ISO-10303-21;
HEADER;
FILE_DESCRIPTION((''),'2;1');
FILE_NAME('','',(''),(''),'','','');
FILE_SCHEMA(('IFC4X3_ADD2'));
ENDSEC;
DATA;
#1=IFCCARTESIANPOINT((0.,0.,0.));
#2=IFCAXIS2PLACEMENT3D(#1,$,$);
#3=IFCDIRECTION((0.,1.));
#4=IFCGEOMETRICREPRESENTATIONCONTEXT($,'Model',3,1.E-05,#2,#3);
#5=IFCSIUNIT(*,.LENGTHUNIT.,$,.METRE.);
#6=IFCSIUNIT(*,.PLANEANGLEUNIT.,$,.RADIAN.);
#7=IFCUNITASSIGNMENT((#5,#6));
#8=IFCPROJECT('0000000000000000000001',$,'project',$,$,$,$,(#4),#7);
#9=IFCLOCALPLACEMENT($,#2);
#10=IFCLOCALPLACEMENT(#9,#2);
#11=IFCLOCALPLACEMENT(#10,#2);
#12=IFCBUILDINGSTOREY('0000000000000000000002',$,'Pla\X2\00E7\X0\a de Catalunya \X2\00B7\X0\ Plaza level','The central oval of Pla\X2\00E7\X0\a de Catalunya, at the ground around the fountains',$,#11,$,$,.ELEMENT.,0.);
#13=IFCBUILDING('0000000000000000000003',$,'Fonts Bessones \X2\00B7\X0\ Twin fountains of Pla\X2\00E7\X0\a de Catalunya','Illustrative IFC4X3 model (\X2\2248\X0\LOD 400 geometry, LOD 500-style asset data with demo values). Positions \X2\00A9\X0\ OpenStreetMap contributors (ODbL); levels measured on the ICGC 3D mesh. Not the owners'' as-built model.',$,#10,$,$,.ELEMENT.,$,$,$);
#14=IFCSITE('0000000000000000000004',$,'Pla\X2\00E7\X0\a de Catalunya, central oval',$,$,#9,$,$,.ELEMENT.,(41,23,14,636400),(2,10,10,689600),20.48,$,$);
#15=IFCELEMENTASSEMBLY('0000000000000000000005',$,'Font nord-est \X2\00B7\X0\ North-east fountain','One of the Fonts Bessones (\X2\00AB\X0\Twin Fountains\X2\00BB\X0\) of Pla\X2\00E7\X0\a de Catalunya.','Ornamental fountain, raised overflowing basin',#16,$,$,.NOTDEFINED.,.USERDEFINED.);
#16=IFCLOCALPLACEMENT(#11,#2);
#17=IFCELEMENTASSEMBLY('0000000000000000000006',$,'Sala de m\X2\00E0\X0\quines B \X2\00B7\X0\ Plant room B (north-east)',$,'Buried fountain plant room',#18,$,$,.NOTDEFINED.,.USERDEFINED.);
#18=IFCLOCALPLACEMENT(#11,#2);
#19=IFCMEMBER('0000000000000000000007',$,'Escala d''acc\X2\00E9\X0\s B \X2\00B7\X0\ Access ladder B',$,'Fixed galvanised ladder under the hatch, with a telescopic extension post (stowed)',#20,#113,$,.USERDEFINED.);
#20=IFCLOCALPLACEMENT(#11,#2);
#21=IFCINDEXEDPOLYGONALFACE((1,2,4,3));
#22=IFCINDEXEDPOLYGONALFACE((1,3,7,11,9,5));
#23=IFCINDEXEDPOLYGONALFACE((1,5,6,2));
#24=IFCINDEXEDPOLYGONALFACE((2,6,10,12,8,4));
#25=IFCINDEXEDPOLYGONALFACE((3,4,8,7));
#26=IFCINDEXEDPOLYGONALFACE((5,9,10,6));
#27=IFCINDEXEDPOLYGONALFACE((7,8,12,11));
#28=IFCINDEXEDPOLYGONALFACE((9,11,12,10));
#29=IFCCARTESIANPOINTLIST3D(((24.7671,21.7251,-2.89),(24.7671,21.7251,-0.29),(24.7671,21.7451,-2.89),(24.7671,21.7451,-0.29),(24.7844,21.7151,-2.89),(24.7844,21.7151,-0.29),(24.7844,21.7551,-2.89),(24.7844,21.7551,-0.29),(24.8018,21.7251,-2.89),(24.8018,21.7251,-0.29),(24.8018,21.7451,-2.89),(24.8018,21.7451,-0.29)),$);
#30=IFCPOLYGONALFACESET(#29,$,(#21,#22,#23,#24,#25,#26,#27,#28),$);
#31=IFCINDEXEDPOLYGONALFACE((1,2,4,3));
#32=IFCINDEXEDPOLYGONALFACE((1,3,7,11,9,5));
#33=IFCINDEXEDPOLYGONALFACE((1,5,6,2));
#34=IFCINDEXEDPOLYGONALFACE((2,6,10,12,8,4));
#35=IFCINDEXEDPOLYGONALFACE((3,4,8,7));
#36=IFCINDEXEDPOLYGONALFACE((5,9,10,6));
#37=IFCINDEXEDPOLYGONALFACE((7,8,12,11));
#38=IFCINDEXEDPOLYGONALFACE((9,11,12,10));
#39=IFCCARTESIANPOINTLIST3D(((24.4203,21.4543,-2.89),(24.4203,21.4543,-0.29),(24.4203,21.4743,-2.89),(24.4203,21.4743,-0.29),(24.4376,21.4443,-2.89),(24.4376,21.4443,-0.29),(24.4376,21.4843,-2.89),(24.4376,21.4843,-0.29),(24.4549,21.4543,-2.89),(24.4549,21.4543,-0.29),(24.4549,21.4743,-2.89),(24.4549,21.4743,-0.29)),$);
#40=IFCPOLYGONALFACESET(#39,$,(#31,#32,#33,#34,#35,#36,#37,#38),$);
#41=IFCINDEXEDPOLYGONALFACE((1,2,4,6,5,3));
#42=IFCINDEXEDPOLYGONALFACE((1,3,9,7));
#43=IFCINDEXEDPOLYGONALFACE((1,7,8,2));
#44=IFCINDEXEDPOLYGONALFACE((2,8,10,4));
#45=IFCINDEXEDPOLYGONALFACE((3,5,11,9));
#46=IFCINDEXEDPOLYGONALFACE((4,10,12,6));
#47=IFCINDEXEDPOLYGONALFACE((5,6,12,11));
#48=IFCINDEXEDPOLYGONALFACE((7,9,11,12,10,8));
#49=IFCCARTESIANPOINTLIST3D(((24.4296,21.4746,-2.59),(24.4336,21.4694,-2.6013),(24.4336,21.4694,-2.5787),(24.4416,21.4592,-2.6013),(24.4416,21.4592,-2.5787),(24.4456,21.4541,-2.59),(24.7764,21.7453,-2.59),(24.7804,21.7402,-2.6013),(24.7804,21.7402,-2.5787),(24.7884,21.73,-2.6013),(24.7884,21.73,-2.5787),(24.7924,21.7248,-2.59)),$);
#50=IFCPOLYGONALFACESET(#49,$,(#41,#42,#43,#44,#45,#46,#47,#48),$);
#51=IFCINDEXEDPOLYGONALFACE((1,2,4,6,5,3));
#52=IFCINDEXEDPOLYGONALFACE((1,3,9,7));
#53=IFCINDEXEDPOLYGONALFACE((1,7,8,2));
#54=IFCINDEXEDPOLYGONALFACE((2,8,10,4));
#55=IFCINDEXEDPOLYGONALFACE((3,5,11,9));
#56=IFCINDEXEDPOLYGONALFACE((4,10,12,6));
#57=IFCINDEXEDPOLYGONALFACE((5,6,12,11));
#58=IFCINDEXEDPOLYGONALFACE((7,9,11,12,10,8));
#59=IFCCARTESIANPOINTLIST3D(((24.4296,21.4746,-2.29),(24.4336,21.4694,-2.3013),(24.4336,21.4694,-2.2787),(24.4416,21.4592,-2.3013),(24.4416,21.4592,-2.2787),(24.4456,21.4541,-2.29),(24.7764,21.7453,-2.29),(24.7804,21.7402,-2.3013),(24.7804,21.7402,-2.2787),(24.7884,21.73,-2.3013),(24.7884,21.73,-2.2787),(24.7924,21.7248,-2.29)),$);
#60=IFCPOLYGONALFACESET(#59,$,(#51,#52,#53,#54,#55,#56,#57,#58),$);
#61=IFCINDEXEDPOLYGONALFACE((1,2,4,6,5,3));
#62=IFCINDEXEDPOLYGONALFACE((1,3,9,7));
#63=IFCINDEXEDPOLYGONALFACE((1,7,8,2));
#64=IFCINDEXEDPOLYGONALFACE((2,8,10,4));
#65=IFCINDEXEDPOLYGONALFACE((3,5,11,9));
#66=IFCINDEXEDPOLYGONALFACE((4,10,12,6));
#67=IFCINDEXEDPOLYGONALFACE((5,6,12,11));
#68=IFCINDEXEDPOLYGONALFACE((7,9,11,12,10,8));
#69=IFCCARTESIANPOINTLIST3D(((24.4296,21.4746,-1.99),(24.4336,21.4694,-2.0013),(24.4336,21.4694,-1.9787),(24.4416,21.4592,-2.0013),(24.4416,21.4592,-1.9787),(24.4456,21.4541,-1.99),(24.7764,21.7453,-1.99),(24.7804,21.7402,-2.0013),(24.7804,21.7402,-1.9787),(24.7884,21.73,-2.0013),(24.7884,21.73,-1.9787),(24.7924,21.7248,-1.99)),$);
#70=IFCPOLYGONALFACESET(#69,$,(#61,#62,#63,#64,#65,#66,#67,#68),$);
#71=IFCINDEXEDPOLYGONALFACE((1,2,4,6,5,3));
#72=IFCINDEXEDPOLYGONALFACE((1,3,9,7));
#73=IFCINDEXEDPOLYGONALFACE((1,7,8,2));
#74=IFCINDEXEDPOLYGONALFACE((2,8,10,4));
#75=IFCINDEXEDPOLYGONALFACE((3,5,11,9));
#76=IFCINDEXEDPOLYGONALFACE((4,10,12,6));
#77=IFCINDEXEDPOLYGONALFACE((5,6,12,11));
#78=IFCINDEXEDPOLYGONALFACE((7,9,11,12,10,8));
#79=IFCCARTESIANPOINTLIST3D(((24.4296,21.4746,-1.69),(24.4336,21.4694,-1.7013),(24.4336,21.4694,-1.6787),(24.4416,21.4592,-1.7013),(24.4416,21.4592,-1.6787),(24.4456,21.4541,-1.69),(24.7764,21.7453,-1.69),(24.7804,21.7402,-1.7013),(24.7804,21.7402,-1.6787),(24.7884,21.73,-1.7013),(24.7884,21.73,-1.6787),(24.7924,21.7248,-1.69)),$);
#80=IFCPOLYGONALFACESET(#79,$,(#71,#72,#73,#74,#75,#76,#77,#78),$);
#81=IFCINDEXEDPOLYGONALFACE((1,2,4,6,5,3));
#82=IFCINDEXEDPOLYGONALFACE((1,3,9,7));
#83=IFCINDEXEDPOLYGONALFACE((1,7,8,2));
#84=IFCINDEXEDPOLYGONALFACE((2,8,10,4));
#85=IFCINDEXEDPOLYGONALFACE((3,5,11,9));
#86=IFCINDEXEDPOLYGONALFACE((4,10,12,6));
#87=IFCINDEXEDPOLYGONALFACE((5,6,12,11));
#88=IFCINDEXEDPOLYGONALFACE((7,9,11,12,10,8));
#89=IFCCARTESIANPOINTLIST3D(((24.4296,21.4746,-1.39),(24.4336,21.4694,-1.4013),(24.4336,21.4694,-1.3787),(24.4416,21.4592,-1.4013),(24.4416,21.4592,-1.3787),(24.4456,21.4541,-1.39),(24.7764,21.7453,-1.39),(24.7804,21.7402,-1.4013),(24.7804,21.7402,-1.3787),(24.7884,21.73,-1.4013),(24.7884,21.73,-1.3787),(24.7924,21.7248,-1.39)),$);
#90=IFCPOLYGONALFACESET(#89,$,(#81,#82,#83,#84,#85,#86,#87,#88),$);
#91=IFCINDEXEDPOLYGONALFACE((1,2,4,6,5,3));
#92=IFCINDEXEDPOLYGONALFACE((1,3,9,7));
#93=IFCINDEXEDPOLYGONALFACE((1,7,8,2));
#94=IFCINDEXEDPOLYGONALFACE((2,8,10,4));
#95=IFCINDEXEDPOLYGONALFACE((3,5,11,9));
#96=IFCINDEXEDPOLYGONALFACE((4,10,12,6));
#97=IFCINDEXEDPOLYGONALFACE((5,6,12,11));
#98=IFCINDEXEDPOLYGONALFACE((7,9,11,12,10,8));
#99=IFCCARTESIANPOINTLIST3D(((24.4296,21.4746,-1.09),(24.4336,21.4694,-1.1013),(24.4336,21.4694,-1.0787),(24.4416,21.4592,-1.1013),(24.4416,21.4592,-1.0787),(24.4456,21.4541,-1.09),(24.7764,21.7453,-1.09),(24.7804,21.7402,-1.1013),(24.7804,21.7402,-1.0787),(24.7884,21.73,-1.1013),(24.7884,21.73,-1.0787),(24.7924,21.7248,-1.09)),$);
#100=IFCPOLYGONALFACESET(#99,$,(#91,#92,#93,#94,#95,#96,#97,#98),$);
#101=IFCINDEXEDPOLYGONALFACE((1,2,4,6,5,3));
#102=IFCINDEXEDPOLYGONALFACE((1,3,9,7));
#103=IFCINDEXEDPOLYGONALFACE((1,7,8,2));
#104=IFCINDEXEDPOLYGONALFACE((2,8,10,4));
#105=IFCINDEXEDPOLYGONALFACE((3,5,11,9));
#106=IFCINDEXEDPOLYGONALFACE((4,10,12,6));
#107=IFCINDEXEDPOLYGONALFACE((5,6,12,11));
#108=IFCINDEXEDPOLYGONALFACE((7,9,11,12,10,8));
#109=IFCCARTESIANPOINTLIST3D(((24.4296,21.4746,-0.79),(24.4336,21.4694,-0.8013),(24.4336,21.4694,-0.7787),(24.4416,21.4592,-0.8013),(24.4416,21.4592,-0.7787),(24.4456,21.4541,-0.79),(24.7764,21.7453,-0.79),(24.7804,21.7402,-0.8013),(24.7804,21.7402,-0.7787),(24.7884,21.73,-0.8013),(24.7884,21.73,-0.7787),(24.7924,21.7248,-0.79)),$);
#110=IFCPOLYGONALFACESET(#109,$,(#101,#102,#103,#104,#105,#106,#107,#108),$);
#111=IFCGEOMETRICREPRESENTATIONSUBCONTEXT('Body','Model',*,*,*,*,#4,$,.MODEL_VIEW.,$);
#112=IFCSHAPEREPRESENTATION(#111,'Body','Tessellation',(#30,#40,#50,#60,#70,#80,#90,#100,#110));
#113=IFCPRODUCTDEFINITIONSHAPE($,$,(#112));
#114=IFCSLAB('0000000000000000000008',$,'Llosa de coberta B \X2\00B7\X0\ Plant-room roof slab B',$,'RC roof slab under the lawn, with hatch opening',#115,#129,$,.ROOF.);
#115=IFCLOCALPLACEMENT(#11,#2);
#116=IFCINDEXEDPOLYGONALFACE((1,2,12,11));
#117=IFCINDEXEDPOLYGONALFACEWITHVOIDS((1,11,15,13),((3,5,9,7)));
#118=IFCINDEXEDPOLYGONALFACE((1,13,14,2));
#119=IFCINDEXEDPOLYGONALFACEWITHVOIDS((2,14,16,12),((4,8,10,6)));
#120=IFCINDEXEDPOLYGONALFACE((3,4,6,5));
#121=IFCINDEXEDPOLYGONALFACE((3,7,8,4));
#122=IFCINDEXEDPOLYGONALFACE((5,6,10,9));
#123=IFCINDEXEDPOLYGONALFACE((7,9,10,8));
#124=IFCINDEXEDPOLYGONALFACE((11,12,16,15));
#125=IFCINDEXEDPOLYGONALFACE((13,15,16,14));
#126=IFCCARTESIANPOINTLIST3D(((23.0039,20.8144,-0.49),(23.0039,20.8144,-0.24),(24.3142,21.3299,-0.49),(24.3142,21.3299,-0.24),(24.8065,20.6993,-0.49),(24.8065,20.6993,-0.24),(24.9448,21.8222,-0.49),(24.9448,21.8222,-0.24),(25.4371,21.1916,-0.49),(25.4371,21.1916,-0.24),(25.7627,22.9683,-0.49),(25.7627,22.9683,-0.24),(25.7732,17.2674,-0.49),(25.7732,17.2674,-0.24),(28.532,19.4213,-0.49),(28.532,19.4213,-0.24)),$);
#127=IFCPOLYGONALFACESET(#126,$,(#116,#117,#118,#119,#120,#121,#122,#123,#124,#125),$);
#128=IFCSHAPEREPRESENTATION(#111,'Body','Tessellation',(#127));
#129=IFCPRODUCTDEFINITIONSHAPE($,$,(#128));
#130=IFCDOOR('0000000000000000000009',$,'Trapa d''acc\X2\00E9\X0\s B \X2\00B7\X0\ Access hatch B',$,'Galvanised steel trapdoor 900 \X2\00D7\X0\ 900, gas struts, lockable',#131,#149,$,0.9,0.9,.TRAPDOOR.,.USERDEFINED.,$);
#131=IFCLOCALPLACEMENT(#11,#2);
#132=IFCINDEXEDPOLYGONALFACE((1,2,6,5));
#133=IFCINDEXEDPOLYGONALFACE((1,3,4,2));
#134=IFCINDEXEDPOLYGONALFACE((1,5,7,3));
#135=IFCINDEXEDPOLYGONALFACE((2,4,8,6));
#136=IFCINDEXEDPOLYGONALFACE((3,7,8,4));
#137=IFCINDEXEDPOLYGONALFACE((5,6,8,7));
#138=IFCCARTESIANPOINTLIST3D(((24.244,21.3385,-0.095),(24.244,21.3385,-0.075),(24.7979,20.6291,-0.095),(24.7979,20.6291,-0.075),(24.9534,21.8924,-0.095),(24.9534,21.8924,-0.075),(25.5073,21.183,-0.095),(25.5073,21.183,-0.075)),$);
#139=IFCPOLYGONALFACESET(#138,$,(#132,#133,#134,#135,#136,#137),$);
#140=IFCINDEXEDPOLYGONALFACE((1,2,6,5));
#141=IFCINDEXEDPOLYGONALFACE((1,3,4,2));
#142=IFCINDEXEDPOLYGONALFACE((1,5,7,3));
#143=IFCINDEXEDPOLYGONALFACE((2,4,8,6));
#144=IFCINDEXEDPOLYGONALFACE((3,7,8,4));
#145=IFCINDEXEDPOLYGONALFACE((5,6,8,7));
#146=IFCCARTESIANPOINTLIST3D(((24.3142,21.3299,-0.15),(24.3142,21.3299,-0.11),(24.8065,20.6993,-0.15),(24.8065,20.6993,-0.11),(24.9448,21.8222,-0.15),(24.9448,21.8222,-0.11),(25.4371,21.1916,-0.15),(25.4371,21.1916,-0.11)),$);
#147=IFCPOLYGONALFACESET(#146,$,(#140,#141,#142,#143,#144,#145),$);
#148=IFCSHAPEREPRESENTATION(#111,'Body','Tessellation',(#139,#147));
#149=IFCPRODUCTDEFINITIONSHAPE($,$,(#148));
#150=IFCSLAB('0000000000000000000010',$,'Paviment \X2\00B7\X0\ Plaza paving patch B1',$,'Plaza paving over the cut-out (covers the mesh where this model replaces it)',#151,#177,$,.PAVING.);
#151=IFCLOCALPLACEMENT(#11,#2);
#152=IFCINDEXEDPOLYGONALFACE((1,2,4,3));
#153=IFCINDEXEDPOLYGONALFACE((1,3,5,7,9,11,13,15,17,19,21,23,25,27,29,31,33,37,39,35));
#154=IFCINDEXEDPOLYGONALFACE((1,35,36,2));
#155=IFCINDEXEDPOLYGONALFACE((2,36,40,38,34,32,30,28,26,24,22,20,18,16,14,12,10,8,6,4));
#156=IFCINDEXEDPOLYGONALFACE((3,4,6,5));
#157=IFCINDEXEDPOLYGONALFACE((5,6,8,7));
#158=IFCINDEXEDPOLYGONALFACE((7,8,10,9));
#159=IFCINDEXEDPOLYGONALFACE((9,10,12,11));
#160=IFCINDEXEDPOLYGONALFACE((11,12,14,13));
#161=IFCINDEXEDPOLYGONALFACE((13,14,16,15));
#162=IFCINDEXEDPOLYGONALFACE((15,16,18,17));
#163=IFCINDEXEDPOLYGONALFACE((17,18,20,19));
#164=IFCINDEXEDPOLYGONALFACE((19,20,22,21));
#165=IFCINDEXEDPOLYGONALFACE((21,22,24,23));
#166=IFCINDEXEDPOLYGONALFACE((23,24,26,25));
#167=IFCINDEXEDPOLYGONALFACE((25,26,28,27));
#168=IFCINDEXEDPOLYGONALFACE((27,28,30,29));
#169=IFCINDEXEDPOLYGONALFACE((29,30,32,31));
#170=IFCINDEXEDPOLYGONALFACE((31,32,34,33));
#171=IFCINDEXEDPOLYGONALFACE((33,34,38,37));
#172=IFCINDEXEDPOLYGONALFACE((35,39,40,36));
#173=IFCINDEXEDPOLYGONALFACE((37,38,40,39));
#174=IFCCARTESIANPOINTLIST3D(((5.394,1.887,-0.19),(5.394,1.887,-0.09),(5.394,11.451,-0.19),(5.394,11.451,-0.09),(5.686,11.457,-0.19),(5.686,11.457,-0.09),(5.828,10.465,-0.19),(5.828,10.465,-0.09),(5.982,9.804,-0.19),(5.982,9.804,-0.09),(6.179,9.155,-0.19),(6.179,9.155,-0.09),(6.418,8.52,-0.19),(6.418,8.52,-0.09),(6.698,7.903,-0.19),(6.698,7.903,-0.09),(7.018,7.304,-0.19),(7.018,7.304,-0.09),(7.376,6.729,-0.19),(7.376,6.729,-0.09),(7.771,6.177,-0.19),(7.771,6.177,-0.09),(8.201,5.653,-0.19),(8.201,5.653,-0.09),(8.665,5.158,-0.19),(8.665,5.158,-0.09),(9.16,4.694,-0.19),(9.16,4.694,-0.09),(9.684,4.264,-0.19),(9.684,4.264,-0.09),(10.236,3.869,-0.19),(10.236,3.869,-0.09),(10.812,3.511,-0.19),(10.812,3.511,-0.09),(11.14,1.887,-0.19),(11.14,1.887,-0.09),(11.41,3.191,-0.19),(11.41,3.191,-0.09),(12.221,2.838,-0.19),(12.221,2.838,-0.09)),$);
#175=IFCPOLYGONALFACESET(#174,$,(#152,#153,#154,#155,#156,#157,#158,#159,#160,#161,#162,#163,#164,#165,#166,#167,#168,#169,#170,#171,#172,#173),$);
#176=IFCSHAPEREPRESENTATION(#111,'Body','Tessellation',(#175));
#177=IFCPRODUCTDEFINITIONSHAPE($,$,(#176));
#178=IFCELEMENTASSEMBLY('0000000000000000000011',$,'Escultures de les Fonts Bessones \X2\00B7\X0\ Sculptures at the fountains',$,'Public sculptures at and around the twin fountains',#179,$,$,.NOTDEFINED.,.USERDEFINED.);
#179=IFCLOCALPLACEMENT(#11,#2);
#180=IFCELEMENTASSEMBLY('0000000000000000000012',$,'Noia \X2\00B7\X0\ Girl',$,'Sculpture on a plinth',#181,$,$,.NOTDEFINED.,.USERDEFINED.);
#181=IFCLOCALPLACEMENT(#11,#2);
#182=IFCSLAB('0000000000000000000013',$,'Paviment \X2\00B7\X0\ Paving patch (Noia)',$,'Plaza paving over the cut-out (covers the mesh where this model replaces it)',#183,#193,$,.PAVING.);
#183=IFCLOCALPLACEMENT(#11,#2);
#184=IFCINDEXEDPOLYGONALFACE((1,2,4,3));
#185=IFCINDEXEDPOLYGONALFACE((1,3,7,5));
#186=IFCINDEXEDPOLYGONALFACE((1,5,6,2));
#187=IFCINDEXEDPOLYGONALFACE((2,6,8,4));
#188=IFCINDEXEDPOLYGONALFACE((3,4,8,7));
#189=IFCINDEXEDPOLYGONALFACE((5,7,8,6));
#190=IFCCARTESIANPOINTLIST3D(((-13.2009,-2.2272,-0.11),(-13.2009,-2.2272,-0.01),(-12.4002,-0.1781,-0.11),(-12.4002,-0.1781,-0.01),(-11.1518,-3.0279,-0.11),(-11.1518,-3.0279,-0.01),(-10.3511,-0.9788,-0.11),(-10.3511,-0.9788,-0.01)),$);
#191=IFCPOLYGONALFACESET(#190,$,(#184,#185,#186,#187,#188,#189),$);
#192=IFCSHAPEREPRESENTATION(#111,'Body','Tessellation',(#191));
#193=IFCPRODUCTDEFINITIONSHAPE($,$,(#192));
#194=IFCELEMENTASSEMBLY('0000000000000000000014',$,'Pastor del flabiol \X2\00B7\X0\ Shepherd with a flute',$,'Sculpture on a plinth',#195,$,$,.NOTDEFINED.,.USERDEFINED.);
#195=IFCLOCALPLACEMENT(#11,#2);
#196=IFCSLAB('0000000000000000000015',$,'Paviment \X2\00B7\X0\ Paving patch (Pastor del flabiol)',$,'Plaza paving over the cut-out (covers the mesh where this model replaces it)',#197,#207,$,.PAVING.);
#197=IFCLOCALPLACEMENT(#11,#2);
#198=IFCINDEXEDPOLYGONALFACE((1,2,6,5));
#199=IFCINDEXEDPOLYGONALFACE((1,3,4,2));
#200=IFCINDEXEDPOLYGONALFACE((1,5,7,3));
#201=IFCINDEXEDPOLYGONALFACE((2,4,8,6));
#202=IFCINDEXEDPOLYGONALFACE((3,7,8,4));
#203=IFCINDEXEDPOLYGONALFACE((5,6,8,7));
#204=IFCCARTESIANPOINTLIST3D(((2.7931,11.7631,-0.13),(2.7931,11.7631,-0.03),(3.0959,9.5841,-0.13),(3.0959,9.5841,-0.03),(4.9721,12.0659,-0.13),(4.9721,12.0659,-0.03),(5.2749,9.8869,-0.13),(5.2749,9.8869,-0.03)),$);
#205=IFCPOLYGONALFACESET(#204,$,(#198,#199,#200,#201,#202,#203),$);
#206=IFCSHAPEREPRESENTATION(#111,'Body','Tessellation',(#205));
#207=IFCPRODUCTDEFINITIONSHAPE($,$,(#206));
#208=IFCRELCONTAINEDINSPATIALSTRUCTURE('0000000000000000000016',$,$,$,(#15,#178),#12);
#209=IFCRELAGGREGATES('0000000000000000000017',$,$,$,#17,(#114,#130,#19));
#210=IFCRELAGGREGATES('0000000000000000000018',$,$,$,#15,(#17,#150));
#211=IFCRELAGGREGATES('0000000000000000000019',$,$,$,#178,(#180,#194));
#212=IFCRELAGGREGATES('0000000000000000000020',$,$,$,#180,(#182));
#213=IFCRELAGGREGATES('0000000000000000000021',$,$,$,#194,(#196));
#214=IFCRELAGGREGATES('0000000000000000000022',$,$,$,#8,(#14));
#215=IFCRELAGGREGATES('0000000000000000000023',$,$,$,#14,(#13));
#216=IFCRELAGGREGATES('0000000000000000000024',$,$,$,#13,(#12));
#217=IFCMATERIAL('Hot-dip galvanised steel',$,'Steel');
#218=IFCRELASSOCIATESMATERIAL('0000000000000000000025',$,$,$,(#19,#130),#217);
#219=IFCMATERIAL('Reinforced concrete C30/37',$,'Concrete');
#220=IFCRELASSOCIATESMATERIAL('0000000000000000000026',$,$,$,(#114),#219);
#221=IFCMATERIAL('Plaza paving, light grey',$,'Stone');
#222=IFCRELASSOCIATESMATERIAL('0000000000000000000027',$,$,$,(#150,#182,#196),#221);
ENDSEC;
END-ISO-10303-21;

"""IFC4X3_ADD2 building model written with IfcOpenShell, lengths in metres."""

from ifc_helpers import new_model, si_unit, direction, frame, frame_2d, origin, place, context, subcontext, project, spatial, polyline, rectangle, outline, extrude, material, element, fill, aggregate, save


model = new_model("IFC4X3_ADD2")

# Units and contexts
model_context = context("Model", 3, precision=1e-05, world=origin(), true_north=direction((0.0, 1.0)))
body_context = subcontext(model_context, "Body", "Model", "MODEL_VIEW")
ifc_project = project(units=[si_unit("LENGTHUNIT", "METRE"), si_unit("PLANEANGLEUNIT", "RADIAN")], contexts=[model_context])

# Site, building, storey
site_placement = place(None, origin())
site = spatial("IfcSite", under=ifc_project, at=site_placement, Name="Plaça de Catalunya, central oval", CompositionType="ELEMENT", RefLatitude=(41, 23, 14, 636400), RefLongitude=(2, 10, 10, 689600), RefElevation=20.48)
building_placement = place(site_placement, origin())
building = spatial("IfcBuilding", under=site, at=building_placement, Name="Fonts Bessones · Twin fountains of Plaça de Catalunya", Description="Illustrative IFC4X3 model (≈LOD 400 geometry, LOD 500-style asset data with demo values). Positions © OpenStreetMap contributors (ODbL); levels measured on the ICGC 3D mesh. Not the owners' as-built model.", CompositionType="ELEMENT")
storey_placement = place(building_placement, origin())
storey = spatial("IfcBuildingStorey", under=building, at=storey_placement, Name="Plaça de Catalunya · Plaza level", Description="The central oval of Plaça de Catalunya, at the ground around the fountains", CompositionType="ELEMENT", Elevation=0.0)

# Element assemblies, member, slabs, opening, door
assembly_1_placement = place(building_placement, origin())
assembly_1 = element("IfcElementAssembly", 1, at=assembly_1_placement, inside=storey, Name="Font nord-est · North-east fountain", Description="One of the Fonts Bessones («Twin Fountains») of Plaça de Catalunya.", ObjectType="Ornamental fountain, raised overflowing basin", AssemblyPlace="NOTDEFINED", PredefinedType="USERDEFINED")
assembly_2_placement = place(building_placement, origin())
assembly_2 = element("IfcElementAssembly", 2, at=assembly_2_placement, Name="Sala de màquines B · Plant room B (north-east)", ObjectType="Buried fountain plant room", AssemblyPlace="NOTDEFINED", PredefinedType="USERDEFINED")
ifc_material_1 = material(Name="Hot-dip galvanised steel", Category="Steel")
member_placement = place(building_placement, origin())
member = element("IfcMember", 3, at=member_placement, material=ifc_material_1, Name="Escala d'accés B · Access ladder B", ObjectType="Fixed galvanised ladder under the hatch, with a telescopic extension post (stowed)", PredefinedType="USERDEFINED", context=body_context, shape_type="SweptSolid", body=[
    extrude(outline(polyline([(0.02, 0.0), (0.01, 0.0173), (-0.01, 0.0173), (-0.02, 0.0), (-0.01, -0.0173), (0.01, -0.0173), (0.02, 0.0)])), frame((24.7844, 21.7351, -2.89), z_axis=(0.0, 0.0, 1.0), x_axis=(0.0, 1.0, 0.0)), (0.0, 0.0, 1.0), 2.6),
    extrude(outline(polyline([(0.02, 0.0), (0.01, 0.0173), (-0.01, 0.0173), (-0.02, 0.0), (-0.01, -0.0173), (0.01, -0.0173), (0.02, 0.0)])), frame((24.4376, 21.4643, -2.89), z_axis=(0.0, 0.0, 1.0), x_axis=(0.0, 1.0, 0.0)), (0.0, 0.0, 1.0), 2.6),
    extrude(outline(polyline([(0.013, 0.0), (0.0065, 0.0113), (-0.0065, 0.0113), (-0.013, 0.0), (-0.0065, -0.0113), (0.0065, -0.0113), (0.013, 0.0)])), frame((24.7844, 21.7351, -2.59), z_axis=(-0.788223, -0.61539, 0.0), x_axis=(-0.61539, 0.788223, 0.0)), (0.0, 0.0, 1.0), 0.44),
    extrude(outline(polyline([(0.013, 0.0), (0.0065, 0.0113), (-0.0065, 0.0113), (-0.013, 0.0), (-0.0065, -0.0113), (0.0065, -0.0113), (0.013, 0.0)])), frame((24.7844, 21.7351, -2.29), z_axis=(-0.788223, -0.61539, 0.0), x_axis=(-0.61539, 0.788223, 0.0)), (0.0, 0.0, 1.0), 0.44),
    extrude(outline(polyline([(0.013, 0.0), (0.0065, 0.0113), (-0.0065, 0.0113), (-0.013, 0.0), (-0.0065, -0.0113), (0.0065, -0.0113), (0.013, 0.0)])), frame((24.7844, 21.7351, -1.99), z_axis=(-0.788223, -0.61539, 0.0), x_axis=(-0.61539, 0.788223, 0.0)), (0.0, 0.0, 1.0), 0.44),
    extrude(outline(polyline([(0.013, 0.0), (0.0065, 0.0113), (-0.0065, 0.0113), (-0.013, 0.0), (-0.0065, -0.0113), (0.0065, -0.0113), (0.013, 0.0)])), frame((24.7844, 21.7351, -1.69), z_axis=(-0.788223, -0.61539, 0.0), x_axis=(-0.61539, 0.788223, 0.0)), (0.0, 0.0, 1.0), 0.44),
    extrude(outline(polyline([(0.013, 0.0), (0.0065, 0.0113), (-0.0065, 0.0113), (-0.013, 0.0), (-0.0065, -0.0113), (0.0065, -0.0113), (0.013, 0.0)])), frame((24.7844, 21.7351, -1.39), z_axis=(-0.788223, -0.61539, 0.0), x_axis=(-0.61539, 0.788223, 0.0)), (0.0, 0.0, 1.0), 0.44),
    extrude(outline(polyline([(0.013, 0.0), (0.0065, 0.0113), (-0.0065, 0.0113), (-0.013, 0.0), (-0.0065, -0.0113), (0.0065, -0.0113), (0.013, 0.0)])), frame((24.7844, 21.7351, -1.09), z_axis=(-0.788223, -0.61539, 0.0), x_axis=(-0.61539, 0.788223, 0.0)), (0.0, 0.0, 1.0), 0.44),
    extrude(outline(polyline([(0.013, 0.0), (0.0065, 0.0113), (-0.0065, 0.0113), (-0.013, 0.0), (-0.0065, -0.0113), (0.0065, -0.0113), (0.013, 0.0)])), frame((24.7844, 21.7351, -0.79), z_axis=(-0.788223, -0.61539, 0.0), x_axis=(-0.61539, 0.788223, 0.0)), (0.0, 0.0, 1.0), 0.44),
])
ifc_material_2 = material(Name="Reinforced concrete C30/37", Category="Concrete")
slab_1_placement = place(building_placement, origin())
slab_1 = element("IfcSlab", 4, at=slab_1_placement, material=ifc_material_2, Name="Llosa de coberta B · Plant-room roof slab B", ObjectType="RC roof slab under the lawn, with hatch opening", PredefinedType="ROOF", context=body_context, shape_type="SweptSolid", body=[
    extrude(rectangle(XDim=4.5, YDim=3.5, at=frame_2d((0.0, 0.0), x_axis=(-0.61539, 0.788223))), frame((25.768, 20.1178, -0.49)), (0.0, 0.0, 1.0), 0.25),
])
opening_placement = place(building_placement, origin())
opening = element("IfcOpeningElement", 5, at=opening_placement, cuts=slab_1, PredefinedType="OPENING", context=body_context, shape_type="SweptSolid", body=[
    extrude(rectangle(XDim=0.8, YDim=0.8, at=frame_2d((0.0, 0.0), x_axis=(-0.61539, 0.788223))), frame((24.8757, 21.2608, -0.54)), (0.0, 0.0, 1.0), 0.35),
])
door_placement = place(building_placement, origin())
door = element("IfcDoor", 6, at=door_placement, material=ifc_material_1, Name="Trapa d'accés B · Access hatch B", ObjectType="Galvanised steel trapdoor 900 × 900, gas struts, lockable", OperationType="USERDEFINED", OverallHeight=0.9, OverallWidth=0.9, PredefinedType="TRAPDOOR", context=body_context, shape_type="SweptSolid", body=[
    extrude(rectangle(XDim=0.9, YDim=0.9, at=frame_2d((0.0, 0.0), x_axis=(-0.61539, 0.788223))), frame((24.8757, 21.2608, -0.095)), (0.0, 0.0, 1.0), 0.02),
    extrude(rectangle(XDim=0.8, YDim=0.8, at=frame_2d((0.0, 0.0), x_axis=(-0.61539, 0.788223))), frame((24.8757, 21.2608, -0.15)), (0.0, 0.0, 1.0), 0.04),
])
fill(opening, door)
ifc_material_3 = material(Name="Plaza paving, light grey", Category="Stone")
slab_2_placement = place(building_placement, origin())
slab_2 = element("IfcSlab", 7, at=slab_2_placement, material=ifc_material_3, Name="Paviment · Plaza paving patch B1", ObjectType="Plaza paving over the cut-out (covers the mesh where this model replaces it)", PredefinedType="PAVING", context=body_context, shape_type="SweptSolid", body=[
    extrude(outline(polyline([(5.394, 11.451), (5.686, 11.457), (5.828, 10.465), (5.982, 9.804), (6.179, 9.155), (6.418, 8.52), (6.698, 7.903), (7.018, 7.304), (7.376, 6.729), (7.771, 6.177), (8.201, 5.653), (8.665, 5.158), (9.16, 4.694), (9.684, 4.264), (10.236, 3.869), (10.812, 3.511), (11.41, 3.191), (12.221, 2.838), (11.14, 1.887), (5.394, 1.887), (5.394, 11.451)]), holes=[]), frame((0.0, 0.0, -0.19)), (0.0, 0.0, 1.0), 0.1),
])

# Element assemblies, slabs
assembly_3_placement = place(building_placement, origin())
assembly_3 = element("IfcElementAssembly", 8, at=assembly_3_placement, inside=storey, Name="Escultures de les Fonts Bessones · Sculptures at the fountains", ObjectType="Public sculptures at and around the twin fountains", AssemblyPlace="NOTDEFINED", PredefinedType="USERDEFINED")
assembly_4_placement = place(building_placement, origin())
assembly_4 = element("IfcElementAssembly", 9, at=assembly_4_placement, Name="Noia · Girl", ObjectType="Sculpture on a plinth", AssemblyPlace="NOTDEFINED", PredefinedType="USERDEFINED")
slab_3_placement = place(building_placement, origin())
slab_3 = element("IfcSlab", 10, at=slab_3_placement, material=ifc_material_3, Name="Paviment · Paving patch (Noia)", ObjectType="Plaza paving over the cut-out (covers the mesh where this model replaces it)", PredefinedType="PAVING", context=body_context, shape_type="SweptSolid", body=[
    extrude(rectangle(XDim=2.2, YDim=2.2, at=frame_2d((0.0, 0.0), x_axis=(0.363941, 0.931422))), frame((-11.776, -1.603, -0.11)), (0.0, 0.0, 1.0), 0.1),
])
assembly_5_placement = place(building_placement, origin())
assembly_5 = element("IfcElementAssembly", 11, at=assembly_5_placement, Name="Pastor del flabiol · Shepherd with a flute", ObjectType="Sculpture on a plinth", AssemblyPlace="NOTDEFINED", PredefinedType="USERDEFINED")
slab_4_placement = place(building_placement, origin())
slab_4 = element("IfcSlab", 12, at=slab_4_placement, material=ifc_material_3, Name="Paviment · Paving patch (Pastor del flabiol)", ObjectType="Plaza paving over the cut-out (covers the mesh where this model replaces it)", PredefinedType="PAVING", context=body_context, shape_type="SweptSolid", body=[
    extrude(rectangle(XDim=2.2, YDim=2.2, at=frame_2d((0.0, 0.0), x_axis=(-0.990482, -0.137641))), frame((4.034, 10.825, -0.13)), (0.0, 0.0, 1.0), 0.1),
])

aggregate(assembly_2, [slab_1, door, member])

aggregate(assembly_1, [assembly_2, slab_2])

aggregate(assembly_3, [assembly_4, assembly_5])

aggregate(assembly_4, [slab_3])
aggregate(assembly_5, [slab_4])

save(model, "model.ifc")
